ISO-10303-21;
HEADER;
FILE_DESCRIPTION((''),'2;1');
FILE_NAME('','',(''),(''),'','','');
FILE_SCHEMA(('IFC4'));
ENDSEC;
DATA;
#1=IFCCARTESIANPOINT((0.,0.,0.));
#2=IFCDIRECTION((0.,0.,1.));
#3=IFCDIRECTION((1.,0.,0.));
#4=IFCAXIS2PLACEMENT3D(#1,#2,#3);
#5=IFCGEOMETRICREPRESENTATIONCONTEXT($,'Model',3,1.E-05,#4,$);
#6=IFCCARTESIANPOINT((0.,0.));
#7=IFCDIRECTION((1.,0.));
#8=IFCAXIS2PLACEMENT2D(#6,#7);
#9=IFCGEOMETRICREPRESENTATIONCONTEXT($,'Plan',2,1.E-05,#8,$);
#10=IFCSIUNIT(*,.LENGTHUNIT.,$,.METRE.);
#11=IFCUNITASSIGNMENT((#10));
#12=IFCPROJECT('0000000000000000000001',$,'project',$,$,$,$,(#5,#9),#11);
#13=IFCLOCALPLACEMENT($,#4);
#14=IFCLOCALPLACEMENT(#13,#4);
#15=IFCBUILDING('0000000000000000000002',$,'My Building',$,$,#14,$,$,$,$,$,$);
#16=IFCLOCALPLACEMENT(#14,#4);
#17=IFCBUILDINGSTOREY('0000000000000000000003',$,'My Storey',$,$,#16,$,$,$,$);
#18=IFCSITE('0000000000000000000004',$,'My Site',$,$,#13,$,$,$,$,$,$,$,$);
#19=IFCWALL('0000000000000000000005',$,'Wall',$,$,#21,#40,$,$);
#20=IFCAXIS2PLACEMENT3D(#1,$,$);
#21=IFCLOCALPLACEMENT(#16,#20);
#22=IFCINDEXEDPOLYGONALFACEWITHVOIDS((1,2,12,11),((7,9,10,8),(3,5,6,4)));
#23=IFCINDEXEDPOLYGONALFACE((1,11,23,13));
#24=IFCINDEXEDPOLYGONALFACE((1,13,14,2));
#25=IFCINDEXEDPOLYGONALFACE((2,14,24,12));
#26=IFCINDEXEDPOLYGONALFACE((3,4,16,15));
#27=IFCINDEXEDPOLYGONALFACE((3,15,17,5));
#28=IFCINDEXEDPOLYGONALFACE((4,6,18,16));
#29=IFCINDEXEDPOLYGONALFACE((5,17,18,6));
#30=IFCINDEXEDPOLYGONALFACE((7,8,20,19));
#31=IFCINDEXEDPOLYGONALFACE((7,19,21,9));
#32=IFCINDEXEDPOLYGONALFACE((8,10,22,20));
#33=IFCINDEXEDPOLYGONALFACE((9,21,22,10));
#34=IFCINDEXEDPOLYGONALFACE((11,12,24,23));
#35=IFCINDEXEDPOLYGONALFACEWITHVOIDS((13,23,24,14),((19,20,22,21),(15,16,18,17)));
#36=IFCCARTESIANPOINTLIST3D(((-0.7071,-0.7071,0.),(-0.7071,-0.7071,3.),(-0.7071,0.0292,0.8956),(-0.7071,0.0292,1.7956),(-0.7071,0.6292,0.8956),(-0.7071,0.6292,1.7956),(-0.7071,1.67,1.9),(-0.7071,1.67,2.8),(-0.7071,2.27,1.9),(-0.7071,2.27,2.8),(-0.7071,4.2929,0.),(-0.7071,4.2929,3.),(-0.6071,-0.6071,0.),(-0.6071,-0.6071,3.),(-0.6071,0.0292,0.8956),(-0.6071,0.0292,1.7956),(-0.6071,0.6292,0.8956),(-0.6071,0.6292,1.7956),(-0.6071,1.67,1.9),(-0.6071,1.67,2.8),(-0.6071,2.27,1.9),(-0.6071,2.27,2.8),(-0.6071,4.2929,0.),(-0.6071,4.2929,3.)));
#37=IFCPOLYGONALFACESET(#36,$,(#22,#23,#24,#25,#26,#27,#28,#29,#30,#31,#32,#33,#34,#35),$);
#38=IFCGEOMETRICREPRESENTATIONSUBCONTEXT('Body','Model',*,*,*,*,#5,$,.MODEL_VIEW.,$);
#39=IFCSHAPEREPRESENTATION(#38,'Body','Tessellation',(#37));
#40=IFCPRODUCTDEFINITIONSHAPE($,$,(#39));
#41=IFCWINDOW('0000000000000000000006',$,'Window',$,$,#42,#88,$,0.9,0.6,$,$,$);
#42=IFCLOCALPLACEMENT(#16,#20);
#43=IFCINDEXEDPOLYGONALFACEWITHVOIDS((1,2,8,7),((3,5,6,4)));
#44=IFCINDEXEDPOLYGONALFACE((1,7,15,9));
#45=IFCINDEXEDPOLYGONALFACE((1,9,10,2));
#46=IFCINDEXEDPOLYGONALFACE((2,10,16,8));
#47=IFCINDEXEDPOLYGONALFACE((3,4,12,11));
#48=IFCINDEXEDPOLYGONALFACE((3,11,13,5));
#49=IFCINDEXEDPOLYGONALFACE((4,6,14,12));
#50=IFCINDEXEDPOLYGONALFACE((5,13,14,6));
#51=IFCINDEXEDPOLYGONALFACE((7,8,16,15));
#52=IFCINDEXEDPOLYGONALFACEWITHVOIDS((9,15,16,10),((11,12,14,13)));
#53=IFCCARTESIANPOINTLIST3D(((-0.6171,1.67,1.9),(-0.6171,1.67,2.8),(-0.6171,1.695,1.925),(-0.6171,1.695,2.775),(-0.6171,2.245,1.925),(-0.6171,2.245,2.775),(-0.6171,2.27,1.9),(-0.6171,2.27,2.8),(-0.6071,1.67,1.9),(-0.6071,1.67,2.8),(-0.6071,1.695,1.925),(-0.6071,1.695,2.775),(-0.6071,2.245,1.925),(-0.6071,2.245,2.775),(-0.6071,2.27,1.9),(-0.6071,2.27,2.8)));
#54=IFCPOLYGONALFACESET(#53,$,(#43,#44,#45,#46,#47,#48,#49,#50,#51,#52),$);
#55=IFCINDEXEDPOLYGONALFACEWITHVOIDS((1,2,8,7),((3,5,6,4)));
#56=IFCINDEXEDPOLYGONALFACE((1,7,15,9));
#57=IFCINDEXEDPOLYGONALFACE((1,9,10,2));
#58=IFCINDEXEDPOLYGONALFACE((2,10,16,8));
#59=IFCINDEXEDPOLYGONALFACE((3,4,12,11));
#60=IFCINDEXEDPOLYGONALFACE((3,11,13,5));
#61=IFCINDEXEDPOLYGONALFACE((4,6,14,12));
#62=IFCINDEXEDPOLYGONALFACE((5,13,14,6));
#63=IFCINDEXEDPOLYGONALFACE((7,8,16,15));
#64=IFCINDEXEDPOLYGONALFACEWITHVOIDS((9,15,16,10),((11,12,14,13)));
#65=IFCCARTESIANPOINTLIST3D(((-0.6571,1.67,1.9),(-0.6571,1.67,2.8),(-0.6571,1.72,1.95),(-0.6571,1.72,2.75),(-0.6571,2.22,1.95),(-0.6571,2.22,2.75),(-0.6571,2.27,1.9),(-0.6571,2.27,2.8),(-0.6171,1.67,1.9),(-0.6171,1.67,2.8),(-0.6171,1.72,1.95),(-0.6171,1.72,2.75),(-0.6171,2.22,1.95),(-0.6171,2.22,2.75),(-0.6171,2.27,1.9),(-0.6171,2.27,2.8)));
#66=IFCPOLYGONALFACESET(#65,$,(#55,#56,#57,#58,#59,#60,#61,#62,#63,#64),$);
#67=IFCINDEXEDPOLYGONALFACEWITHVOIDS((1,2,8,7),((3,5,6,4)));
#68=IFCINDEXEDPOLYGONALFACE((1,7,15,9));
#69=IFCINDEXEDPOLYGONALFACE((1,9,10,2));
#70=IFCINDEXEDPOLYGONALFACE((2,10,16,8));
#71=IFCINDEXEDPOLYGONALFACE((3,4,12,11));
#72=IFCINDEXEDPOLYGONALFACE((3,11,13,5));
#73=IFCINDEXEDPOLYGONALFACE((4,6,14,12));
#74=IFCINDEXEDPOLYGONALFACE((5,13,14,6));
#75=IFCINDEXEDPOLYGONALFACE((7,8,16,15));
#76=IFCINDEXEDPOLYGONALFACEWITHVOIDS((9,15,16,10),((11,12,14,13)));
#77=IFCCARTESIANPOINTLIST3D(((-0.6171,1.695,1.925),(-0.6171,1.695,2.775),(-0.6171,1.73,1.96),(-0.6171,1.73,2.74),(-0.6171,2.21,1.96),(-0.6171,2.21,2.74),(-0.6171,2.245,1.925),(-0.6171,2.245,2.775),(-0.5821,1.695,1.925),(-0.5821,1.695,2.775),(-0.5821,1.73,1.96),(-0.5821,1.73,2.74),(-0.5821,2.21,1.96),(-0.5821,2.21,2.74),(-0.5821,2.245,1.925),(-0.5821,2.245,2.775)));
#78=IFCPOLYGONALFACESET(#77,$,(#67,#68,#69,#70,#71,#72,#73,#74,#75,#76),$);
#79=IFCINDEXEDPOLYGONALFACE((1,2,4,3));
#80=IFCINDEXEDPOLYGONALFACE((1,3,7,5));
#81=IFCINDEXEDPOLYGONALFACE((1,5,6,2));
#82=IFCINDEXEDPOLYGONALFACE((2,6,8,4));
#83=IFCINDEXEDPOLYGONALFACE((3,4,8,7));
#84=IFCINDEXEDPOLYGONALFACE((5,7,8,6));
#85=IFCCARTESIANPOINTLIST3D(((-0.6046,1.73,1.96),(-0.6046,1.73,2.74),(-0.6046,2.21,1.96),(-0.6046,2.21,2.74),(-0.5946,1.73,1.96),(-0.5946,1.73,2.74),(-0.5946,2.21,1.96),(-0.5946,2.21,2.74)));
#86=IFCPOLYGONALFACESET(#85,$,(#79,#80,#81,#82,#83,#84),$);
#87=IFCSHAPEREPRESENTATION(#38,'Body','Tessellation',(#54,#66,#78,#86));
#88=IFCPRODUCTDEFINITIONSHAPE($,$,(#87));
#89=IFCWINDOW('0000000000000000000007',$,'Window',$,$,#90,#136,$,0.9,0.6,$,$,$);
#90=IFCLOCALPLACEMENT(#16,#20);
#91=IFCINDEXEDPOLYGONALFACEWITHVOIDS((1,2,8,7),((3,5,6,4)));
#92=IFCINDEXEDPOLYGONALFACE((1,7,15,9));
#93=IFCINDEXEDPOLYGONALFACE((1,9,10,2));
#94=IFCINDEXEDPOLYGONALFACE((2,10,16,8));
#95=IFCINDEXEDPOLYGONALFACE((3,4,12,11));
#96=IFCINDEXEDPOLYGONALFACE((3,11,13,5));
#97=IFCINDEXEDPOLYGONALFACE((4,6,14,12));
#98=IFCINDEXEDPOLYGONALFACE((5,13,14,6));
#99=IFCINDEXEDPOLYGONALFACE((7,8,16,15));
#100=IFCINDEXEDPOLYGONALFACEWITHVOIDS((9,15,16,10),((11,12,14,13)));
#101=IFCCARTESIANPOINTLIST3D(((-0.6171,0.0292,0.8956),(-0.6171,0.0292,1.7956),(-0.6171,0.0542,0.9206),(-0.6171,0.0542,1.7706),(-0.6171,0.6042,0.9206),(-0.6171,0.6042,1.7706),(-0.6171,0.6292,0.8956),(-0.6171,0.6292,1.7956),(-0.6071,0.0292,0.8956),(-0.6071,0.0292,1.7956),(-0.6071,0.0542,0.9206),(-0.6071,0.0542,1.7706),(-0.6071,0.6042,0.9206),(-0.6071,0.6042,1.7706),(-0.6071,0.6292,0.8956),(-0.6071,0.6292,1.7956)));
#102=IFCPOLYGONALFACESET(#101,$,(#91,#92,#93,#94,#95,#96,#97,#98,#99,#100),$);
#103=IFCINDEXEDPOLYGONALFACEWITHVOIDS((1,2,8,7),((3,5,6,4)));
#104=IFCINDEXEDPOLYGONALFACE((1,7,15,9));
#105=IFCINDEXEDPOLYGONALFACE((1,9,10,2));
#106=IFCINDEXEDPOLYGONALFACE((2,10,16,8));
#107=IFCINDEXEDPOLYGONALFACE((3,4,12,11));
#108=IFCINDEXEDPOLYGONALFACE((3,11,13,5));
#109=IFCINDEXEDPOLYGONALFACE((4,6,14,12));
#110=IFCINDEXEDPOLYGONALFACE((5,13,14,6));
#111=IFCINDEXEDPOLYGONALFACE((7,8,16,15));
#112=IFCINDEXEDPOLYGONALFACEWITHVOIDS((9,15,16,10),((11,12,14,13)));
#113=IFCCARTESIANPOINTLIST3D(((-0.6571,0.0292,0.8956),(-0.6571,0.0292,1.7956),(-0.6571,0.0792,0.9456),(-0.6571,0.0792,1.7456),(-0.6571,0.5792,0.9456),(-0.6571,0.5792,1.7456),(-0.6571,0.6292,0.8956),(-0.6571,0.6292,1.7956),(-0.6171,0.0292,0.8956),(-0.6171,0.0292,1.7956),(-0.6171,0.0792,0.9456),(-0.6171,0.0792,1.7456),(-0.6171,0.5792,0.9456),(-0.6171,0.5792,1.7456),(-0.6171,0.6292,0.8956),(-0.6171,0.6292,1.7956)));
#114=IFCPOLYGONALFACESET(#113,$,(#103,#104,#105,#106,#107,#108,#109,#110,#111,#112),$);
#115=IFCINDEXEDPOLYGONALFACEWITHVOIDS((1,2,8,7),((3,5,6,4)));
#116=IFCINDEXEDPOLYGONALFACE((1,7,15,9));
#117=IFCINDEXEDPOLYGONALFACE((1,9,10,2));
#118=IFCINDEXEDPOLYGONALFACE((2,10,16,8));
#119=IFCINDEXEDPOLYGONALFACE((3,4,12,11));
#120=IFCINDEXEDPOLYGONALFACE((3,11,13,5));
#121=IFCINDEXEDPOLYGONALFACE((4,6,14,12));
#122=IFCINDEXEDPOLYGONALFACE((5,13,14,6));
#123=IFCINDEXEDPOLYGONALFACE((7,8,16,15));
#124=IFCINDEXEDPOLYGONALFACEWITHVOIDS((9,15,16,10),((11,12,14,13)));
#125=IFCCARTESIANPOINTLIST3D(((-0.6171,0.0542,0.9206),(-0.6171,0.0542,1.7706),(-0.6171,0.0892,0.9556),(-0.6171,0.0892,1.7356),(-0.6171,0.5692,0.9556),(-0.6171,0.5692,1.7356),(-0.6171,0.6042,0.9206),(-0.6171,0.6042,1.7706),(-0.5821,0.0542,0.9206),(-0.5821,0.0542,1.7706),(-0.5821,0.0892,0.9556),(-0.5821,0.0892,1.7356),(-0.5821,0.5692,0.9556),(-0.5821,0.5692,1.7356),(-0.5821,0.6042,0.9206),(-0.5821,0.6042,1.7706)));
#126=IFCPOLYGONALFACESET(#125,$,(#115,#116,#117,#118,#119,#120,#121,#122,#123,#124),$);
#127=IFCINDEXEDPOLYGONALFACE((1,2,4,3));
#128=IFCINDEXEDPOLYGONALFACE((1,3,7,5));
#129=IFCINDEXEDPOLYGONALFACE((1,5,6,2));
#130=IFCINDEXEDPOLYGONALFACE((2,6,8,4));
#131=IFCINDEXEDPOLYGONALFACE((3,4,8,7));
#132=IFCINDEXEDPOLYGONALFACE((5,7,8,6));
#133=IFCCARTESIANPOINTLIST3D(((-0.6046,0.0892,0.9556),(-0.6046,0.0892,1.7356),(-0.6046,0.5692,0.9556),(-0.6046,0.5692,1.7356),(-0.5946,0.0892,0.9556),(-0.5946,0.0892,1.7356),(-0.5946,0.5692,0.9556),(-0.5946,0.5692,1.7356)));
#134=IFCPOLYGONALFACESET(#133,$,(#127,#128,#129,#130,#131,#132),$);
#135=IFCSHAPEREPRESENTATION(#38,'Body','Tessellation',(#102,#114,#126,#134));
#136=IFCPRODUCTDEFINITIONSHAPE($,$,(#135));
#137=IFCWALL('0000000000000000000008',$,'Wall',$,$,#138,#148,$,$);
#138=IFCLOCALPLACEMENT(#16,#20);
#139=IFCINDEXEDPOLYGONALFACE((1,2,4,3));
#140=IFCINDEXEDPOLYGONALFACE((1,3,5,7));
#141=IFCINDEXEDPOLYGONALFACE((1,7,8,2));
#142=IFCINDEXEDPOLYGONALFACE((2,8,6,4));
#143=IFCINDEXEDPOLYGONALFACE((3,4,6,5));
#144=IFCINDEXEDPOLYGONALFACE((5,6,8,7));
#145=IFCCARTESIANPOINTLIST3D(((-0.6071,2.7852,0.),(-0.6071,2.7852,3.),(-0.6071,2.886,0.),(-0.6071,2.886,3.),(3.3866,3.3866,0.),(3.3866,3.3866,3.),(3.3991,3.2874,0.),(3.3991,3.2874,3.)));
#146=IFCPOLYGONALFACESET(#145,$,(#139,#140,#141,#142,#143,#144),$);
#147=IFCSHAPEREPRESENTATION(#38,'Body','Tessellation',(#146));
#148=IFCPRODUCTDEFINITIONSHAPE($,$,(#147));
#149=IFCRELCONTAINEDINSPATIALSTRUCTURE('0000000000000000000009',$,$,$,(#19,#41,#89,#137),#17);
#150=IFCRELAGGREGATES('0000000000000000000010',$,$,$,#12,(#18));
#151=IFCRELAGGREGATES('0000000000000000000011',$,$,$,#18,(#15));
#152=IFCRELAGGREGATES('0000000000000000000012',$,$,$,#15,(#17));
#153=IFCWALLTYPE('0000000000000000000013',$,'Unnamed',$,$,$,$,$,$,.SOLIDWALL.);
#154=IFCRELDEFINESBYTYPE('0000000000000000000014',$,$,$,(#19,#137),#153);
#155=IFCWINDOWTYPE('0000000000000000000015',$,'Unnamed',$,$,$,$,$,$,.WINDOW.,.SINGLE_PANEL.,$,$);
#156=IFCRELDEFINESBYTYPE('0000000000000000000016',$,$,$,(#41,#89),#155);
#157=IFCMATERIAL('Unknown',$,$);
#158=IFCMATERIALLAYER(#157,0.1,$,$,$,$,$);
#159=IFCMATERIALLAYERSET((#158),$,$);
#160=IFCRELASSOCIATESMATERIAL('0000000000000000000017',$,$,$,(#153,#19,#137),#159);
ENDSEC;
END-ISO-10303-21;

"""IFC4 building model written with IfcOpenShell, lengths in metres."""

from ifc_helpers import new_model, entity, si_unit, frame, origin_with_axes, origin_2d_with_axis, place, context, subcontext, project, spatial, line, indexed_curve, outline, extrude, shape, source, transform, mapped, material, layer, layer_set, layer_usage, type_object, type_shapes, element, fill, save


model = new_model("IFC4")

# Units and contexts
model_context = context("Model", 3, precision=1e-05, world=origin_with_axes())
plan_context = context("Plan", 2, precision=1e-05, world=origin_2d_with_axis())
body_context_1 = subcontext(model_context, "Body", "Model", "MODEL_VIEW")
body_context_2 = subcontext(plan_context, "Body", "Plan", "PLAN_VIEW")
ifc_project = project(units=[si_unit("LENGTHUNIT", "METRE")], contexts=[model_context, plan_context])

# Site, building, storey
site_placement = place(None, origin_with_axes())
site = spatial("IfcSite", under=ifc_project, at=site_placement, Name="My Site")
building_placement = place(site_placement, origin_with_axes())
building = spatial("IfcBuilding", under=site, at=building_placement, Name="My Building")
storey_placement = place(building_placement, origin_with_axes())
storey = spatial("IfcBuildingStorey", under=building, at=storey_placement, Name="My Storey")

# Shared definitions
ifc_material = material(Name="Unknown")

# Shared definitions
ifc_layer_1 = layer(ifc_material, 0.1)
ifc_layer_set_1 = layer_set([ifc_layer_1])
wall_type = type_object("IfcWallType", Name="Unnamed", PredefinedType="SOLIDWALL", material=ifc_layer_set_1)

# Wall, openings, windows
ifc_layer_usage_1 = layer_usage(ifc_layer_set_1, "AXIS2", "POSITIVE", 0.0)
wall_1_placement = place(storey_placement, frame((-0.7071, 4.2929, 0.0), z_axis=(0.0, 0.0, 1.0), x_axis=(0.0, -1.0, 0.0)))
wall_1 = element("IfcWall", 1, at=wall_1_placement, inside=storey, type_object=wall_type, material=ifc_layer_usage_1, Name="Wall", context=body_context_1, shape_type="SweptSolid", body=[
    extrude(outline(indexed_curve([(0.0, 0.0), (0.0, 0.1), (4.9, 0.1), (5.0, 0.0)], segments=[line(1, 2, 3, 4, 1)])), origin_with_axes(), (0.0, 0.0, 1.0), 3.0),
])
shared_shape_1 = source(origin_with_axes(), body_context_1, "Body", "SweptSolid", [
    extrude(outline(indexed_curve([(0.0, 0.0), (0.6, 0.0), (0.6, 0.9), (0.0, 0.9)], segments=[line(1, 2, 3, 4, 1)])), frame((0.0, -0.6, 0.0), z_axis=(0.0, -1.0, 0.0), x_axis=(1.0, 0.0, 0.0)), (0.0, 0.0, -1.0), 1.2),
])
opening_1_placement = place(wall_1_placement, frame((2.0229, 0.0, 1.9), z_axis=(0.0, 0.0, 1.0), x_axis=(1.0, 0.0, 0.0)))
opening_1 = element("IfcOpeningElement", 2, at=opening_1_placement, cuts=wall_1, PredefinedType="OPENING", context=body_context_1, shape_type="MappedRepresentation", body=[
    mapped(shared_shape_1, transform((0.0, 0.0, 0.0), x_axis=(1.0, 0.0, 0.0), y_axis=(0.0, 1.0, 0.0), z_axis=(0.0, 0.0, 1.0), scale=1.0)),
])
opening_2_placement = place(wall_1_placement, frame((3.6637, 0.0, 0.8956), z_axis=(0.0, 0.0, 1.0), x_axis=(1.0, 0.0, 0.0)))
opening_2 = element("IfcOpeningElement", 3, at=opening_2_placement, cuts=wall_1, PredefinedType="OPENING", context=body_context_1, shape_type="MappedRepresentation", body=[
    mapped(shared_shape_1, transform((0.0, 0.0, 0.0), x_axis=(1.0, 0.0, 0.0), y_axis=(0.0, 1.0, 0.0), z_axis=(0.0, 0.0, 1.0), scale=1.0)),
])
window_type = type_object("IfcWindowType", Name="Unnamed", PartitioningType="SINGLE_PANEL", PredefinedType="WINDOW")
shared_shape_2 = source(origin_with_axes(), body_context_1, "Body", "SweptSolid", [
    extrude(outline(indexed_curve([(0.0, 0.0), (0.6, 0.0), (0.6, 0.9), (0.0, 0.9)], segments=[line(1, 2, 3, 4, 1)]), holes=[indexed_curve([(0.025, 0.025), (0.575, 0.025), (0.575, 0.875), (0.025, 0.875)], segments=[line(1, 2, 3, 4, 1)])]), frame((0.0, 0.09, 0.0), z_axis=(0.0, -1.0, 0.0), x_axis=(1.0, 0.0, 0.0)), (0.0, 0.0, -1.0), 0.01),
    extrude(outline(indexed_curve([(0.0, 0.0), (0.6, 0.0), (0.6, 0.9), (0.0, 0.9)], segments=[line(1, 2, 3, 4, 1)]), holes=[indexed_curve([(0.05, 0.05), (0.55, 0.05), (0.55, 0.85), (0.05, 0.85)], segments=[line(1, 2, 3, 4, 1)])]), frame((0.0, 0.05, 0.0), z_axis=(0.0, -1.0, 0.0), x_axis=(1.0, 0.0, 0.0)), (0.0, 0.0, -1.0), 0.04),
    extrude(outline(indexed_curve([(0.0, 0.0), (0.55, 0.0), (0.55, 0.85), (0.0, 0.85)], segments=[line(1, 2, 3, 4, 1)]), holes=[indexed_curve([(0.035, 0.035), (0.515, 0.035), (0.515, 0.815), (0.035, 0.815)], segments=[line(1, 2, 3, 4, 1)])]), frame((0.025, 0.09, 0.025), z_axis=(0.0, -1.0, 0.0), x_axis=(1.0, 0.0, 0.0)), (0.0, 0.0, -1.0), 0.035),
    extrude(outline(indexed_curve([(0.035, 0.035), (0.515, 0.035), (0.515, 0.815), (0.035, 0.815)], segments=[line(1, 2, 3, 4, 1)])), frame((0.025, 0.1025, 0.025), z_axis=(0.0, -1.0, 0.0), x_axis=(1.0, 0.0, 0.0)), (0.0, 0.0, -1.0), 0.01),
])
shared_shape_3 = source(origin_with_axes(), body_context_2, "Body", "Curve2D", [
    entity("IfcIndexedPolyCurve", entity("IfcCartesianPointList2D", [[0.05, 0.05], [0.55, 0.05]])),
    entity("IfcIndexedPolyCurve", entity("IfcCartesianPointList2D", [[0.0, 0.1], [0.025, 0.1], [0.025, 0.09], [0.05, 0.09], [0.05, 0.05], [0.0, 0.05]]), [entity("IfcLineIndex", [1, 2, 3, 4, 5, 6, 1])]),
    entity("IfcIndexedPolyCurve", entity("IfcCartesianPointList2D", [[0.6, 0.1], [0.575, 0.1], [0.575, 0.09], [0.55, 0.09], [0.55, 0.05], [0.6, 0.05]]), [entity("IfcLineIndex", [1, 2, 3, 4, 5, 6, 1])]),
    entity("IfcIndexedPolyCurve", entity("IfcCartesianPointList2D", [[0.025, 0.09], [0.06, 0.09], [0.06, 0.125], [0.025, 0.125]]), [entity("IfcLineIndex", [1, 2, 3, 4, 1])]),
    entity("IfcIndexedPolyCurve", entity("IfcCartesianPointList2D", [[0.575, 0.09], [0.54, 0.09], [0.54, 0.125], [0.575, 0.125]]), [entity("IfcLineIndex", [1, 2, 3, 4, 1])]),
    entity("IfcIndexedPolyCurve", entity("IfcCartesianPointList2D", [[0.06, 0.09], [0.54, 0.09]])),
    entity("IfcIndexedPolyCurve", entity("IfcCartesianPointList2D", [[0.06, 0.125], [0.54, 0.125]])),
    entity("IfcIndexedPolyCurve", entity("IfcCartesianPointList2D", [[0.06, 0.1075], [0.54, 0.1075]])),
])
type_shapes(window_type, [shared_shape_2, shared_shape_3])
window_1_placement = place(opening_1_placement, frame((0.0, 0.0, 0.0), z_axis=(0.0, 0.0, 1.0), x_axis=(1.0, 0.0, 0.0)))
window_1 = element("IfcWindow", 4, at=window_1_placement, inside=storey, type_object=window_type, Name="Window", OverallHeight=0.9, OverallWidth=0.6, shapes=[
    shape(body_context_1, "Body", "MappedRepresentation", [mapped(shared_shape_2, transform((0.0, 0.0, 0.0), x_axis=(1.0, 0.0, 0.0), y_axis=(0.0, 1.0, 0.0), z_axis=(0.0, 0.0, 1.0), scale=1.0))]),
    shape(body_context_2, "Body", "MappedRepresentation", [mapped(shared_shape_3, transform((0.0, 0.0, 0.0), x_axis=(1.0, 0.0, 0.0), y_axis=(0.0, 1.0, 0.0), z_axis=(0.0, 0.0, 1.0), scale=1.0))]),
])
fill(opening_1, window_1)
window_2_placement = place(opening_2_placement, frame((0.0, 0.0, 0.0), z_axis=(0.0, 0.0, 1.0), x_axis=(1.0, 0.0, 0.0)))
window_2 = element("IfcWindow", 5, at=window_2_placement, inside=storey, type_object=window_type, Name="Window", OverallHeight=0.9, OverallWidth=0.6, shapes=[
    shape(body_context_1, "Body", "MappedRepresentation", [mapped(shared_shape_2, transform((0.0, 0.0, 0.0), x_axis=(1.0, 0.0, 0.0), y_axis=(0.0, 1.0, 0.0), z_axis=(0.0, 0.0, 1.0), scale=1.0))]),
    shape(body_context_2, "Body", "MappedRepresentation", [mapped(shared_shape_3, transform((0.0, 0.0, 0.0), x_axis=(1.0, 0.0, 0.0), y_axis=(0.0, 1.0, 0.0), z_axis=(0.0, 0.0, 1.0), scale=1.0))]),
])
fill(opening_2, window_2)

# Wall
ifc_layer_usage_2 = layer_usage(ifc_layer_set_1, "AXIS2", "POSITIVE", 0.0)
wall_2_placement = place(storey_placement, frame((3.3866, 3.3866, 0.0), z_axis=(0.0, 0.0, 1.0), x_axis=(-0.992234, -0.124383, 0.0)))
element("IfcWall", 6, at=wall_2_placement, inside=storey, type_object=wall_type, material=ifc_layer_usage_2, Name="Wall", context=body_context_1, shape_type="SweptSolid", body=[
    extrude(outline(indexed_curve([(0.0, 0.0), (0.0, 0.1), (4.0375, 0.1), (4.025, 0.0)], segments=[line(1, 2, 3, 4, 1)])), origin_with_axes(), (0.0, 0.0, 1.0), 3.0),
])

save(model, "model.ifc")
